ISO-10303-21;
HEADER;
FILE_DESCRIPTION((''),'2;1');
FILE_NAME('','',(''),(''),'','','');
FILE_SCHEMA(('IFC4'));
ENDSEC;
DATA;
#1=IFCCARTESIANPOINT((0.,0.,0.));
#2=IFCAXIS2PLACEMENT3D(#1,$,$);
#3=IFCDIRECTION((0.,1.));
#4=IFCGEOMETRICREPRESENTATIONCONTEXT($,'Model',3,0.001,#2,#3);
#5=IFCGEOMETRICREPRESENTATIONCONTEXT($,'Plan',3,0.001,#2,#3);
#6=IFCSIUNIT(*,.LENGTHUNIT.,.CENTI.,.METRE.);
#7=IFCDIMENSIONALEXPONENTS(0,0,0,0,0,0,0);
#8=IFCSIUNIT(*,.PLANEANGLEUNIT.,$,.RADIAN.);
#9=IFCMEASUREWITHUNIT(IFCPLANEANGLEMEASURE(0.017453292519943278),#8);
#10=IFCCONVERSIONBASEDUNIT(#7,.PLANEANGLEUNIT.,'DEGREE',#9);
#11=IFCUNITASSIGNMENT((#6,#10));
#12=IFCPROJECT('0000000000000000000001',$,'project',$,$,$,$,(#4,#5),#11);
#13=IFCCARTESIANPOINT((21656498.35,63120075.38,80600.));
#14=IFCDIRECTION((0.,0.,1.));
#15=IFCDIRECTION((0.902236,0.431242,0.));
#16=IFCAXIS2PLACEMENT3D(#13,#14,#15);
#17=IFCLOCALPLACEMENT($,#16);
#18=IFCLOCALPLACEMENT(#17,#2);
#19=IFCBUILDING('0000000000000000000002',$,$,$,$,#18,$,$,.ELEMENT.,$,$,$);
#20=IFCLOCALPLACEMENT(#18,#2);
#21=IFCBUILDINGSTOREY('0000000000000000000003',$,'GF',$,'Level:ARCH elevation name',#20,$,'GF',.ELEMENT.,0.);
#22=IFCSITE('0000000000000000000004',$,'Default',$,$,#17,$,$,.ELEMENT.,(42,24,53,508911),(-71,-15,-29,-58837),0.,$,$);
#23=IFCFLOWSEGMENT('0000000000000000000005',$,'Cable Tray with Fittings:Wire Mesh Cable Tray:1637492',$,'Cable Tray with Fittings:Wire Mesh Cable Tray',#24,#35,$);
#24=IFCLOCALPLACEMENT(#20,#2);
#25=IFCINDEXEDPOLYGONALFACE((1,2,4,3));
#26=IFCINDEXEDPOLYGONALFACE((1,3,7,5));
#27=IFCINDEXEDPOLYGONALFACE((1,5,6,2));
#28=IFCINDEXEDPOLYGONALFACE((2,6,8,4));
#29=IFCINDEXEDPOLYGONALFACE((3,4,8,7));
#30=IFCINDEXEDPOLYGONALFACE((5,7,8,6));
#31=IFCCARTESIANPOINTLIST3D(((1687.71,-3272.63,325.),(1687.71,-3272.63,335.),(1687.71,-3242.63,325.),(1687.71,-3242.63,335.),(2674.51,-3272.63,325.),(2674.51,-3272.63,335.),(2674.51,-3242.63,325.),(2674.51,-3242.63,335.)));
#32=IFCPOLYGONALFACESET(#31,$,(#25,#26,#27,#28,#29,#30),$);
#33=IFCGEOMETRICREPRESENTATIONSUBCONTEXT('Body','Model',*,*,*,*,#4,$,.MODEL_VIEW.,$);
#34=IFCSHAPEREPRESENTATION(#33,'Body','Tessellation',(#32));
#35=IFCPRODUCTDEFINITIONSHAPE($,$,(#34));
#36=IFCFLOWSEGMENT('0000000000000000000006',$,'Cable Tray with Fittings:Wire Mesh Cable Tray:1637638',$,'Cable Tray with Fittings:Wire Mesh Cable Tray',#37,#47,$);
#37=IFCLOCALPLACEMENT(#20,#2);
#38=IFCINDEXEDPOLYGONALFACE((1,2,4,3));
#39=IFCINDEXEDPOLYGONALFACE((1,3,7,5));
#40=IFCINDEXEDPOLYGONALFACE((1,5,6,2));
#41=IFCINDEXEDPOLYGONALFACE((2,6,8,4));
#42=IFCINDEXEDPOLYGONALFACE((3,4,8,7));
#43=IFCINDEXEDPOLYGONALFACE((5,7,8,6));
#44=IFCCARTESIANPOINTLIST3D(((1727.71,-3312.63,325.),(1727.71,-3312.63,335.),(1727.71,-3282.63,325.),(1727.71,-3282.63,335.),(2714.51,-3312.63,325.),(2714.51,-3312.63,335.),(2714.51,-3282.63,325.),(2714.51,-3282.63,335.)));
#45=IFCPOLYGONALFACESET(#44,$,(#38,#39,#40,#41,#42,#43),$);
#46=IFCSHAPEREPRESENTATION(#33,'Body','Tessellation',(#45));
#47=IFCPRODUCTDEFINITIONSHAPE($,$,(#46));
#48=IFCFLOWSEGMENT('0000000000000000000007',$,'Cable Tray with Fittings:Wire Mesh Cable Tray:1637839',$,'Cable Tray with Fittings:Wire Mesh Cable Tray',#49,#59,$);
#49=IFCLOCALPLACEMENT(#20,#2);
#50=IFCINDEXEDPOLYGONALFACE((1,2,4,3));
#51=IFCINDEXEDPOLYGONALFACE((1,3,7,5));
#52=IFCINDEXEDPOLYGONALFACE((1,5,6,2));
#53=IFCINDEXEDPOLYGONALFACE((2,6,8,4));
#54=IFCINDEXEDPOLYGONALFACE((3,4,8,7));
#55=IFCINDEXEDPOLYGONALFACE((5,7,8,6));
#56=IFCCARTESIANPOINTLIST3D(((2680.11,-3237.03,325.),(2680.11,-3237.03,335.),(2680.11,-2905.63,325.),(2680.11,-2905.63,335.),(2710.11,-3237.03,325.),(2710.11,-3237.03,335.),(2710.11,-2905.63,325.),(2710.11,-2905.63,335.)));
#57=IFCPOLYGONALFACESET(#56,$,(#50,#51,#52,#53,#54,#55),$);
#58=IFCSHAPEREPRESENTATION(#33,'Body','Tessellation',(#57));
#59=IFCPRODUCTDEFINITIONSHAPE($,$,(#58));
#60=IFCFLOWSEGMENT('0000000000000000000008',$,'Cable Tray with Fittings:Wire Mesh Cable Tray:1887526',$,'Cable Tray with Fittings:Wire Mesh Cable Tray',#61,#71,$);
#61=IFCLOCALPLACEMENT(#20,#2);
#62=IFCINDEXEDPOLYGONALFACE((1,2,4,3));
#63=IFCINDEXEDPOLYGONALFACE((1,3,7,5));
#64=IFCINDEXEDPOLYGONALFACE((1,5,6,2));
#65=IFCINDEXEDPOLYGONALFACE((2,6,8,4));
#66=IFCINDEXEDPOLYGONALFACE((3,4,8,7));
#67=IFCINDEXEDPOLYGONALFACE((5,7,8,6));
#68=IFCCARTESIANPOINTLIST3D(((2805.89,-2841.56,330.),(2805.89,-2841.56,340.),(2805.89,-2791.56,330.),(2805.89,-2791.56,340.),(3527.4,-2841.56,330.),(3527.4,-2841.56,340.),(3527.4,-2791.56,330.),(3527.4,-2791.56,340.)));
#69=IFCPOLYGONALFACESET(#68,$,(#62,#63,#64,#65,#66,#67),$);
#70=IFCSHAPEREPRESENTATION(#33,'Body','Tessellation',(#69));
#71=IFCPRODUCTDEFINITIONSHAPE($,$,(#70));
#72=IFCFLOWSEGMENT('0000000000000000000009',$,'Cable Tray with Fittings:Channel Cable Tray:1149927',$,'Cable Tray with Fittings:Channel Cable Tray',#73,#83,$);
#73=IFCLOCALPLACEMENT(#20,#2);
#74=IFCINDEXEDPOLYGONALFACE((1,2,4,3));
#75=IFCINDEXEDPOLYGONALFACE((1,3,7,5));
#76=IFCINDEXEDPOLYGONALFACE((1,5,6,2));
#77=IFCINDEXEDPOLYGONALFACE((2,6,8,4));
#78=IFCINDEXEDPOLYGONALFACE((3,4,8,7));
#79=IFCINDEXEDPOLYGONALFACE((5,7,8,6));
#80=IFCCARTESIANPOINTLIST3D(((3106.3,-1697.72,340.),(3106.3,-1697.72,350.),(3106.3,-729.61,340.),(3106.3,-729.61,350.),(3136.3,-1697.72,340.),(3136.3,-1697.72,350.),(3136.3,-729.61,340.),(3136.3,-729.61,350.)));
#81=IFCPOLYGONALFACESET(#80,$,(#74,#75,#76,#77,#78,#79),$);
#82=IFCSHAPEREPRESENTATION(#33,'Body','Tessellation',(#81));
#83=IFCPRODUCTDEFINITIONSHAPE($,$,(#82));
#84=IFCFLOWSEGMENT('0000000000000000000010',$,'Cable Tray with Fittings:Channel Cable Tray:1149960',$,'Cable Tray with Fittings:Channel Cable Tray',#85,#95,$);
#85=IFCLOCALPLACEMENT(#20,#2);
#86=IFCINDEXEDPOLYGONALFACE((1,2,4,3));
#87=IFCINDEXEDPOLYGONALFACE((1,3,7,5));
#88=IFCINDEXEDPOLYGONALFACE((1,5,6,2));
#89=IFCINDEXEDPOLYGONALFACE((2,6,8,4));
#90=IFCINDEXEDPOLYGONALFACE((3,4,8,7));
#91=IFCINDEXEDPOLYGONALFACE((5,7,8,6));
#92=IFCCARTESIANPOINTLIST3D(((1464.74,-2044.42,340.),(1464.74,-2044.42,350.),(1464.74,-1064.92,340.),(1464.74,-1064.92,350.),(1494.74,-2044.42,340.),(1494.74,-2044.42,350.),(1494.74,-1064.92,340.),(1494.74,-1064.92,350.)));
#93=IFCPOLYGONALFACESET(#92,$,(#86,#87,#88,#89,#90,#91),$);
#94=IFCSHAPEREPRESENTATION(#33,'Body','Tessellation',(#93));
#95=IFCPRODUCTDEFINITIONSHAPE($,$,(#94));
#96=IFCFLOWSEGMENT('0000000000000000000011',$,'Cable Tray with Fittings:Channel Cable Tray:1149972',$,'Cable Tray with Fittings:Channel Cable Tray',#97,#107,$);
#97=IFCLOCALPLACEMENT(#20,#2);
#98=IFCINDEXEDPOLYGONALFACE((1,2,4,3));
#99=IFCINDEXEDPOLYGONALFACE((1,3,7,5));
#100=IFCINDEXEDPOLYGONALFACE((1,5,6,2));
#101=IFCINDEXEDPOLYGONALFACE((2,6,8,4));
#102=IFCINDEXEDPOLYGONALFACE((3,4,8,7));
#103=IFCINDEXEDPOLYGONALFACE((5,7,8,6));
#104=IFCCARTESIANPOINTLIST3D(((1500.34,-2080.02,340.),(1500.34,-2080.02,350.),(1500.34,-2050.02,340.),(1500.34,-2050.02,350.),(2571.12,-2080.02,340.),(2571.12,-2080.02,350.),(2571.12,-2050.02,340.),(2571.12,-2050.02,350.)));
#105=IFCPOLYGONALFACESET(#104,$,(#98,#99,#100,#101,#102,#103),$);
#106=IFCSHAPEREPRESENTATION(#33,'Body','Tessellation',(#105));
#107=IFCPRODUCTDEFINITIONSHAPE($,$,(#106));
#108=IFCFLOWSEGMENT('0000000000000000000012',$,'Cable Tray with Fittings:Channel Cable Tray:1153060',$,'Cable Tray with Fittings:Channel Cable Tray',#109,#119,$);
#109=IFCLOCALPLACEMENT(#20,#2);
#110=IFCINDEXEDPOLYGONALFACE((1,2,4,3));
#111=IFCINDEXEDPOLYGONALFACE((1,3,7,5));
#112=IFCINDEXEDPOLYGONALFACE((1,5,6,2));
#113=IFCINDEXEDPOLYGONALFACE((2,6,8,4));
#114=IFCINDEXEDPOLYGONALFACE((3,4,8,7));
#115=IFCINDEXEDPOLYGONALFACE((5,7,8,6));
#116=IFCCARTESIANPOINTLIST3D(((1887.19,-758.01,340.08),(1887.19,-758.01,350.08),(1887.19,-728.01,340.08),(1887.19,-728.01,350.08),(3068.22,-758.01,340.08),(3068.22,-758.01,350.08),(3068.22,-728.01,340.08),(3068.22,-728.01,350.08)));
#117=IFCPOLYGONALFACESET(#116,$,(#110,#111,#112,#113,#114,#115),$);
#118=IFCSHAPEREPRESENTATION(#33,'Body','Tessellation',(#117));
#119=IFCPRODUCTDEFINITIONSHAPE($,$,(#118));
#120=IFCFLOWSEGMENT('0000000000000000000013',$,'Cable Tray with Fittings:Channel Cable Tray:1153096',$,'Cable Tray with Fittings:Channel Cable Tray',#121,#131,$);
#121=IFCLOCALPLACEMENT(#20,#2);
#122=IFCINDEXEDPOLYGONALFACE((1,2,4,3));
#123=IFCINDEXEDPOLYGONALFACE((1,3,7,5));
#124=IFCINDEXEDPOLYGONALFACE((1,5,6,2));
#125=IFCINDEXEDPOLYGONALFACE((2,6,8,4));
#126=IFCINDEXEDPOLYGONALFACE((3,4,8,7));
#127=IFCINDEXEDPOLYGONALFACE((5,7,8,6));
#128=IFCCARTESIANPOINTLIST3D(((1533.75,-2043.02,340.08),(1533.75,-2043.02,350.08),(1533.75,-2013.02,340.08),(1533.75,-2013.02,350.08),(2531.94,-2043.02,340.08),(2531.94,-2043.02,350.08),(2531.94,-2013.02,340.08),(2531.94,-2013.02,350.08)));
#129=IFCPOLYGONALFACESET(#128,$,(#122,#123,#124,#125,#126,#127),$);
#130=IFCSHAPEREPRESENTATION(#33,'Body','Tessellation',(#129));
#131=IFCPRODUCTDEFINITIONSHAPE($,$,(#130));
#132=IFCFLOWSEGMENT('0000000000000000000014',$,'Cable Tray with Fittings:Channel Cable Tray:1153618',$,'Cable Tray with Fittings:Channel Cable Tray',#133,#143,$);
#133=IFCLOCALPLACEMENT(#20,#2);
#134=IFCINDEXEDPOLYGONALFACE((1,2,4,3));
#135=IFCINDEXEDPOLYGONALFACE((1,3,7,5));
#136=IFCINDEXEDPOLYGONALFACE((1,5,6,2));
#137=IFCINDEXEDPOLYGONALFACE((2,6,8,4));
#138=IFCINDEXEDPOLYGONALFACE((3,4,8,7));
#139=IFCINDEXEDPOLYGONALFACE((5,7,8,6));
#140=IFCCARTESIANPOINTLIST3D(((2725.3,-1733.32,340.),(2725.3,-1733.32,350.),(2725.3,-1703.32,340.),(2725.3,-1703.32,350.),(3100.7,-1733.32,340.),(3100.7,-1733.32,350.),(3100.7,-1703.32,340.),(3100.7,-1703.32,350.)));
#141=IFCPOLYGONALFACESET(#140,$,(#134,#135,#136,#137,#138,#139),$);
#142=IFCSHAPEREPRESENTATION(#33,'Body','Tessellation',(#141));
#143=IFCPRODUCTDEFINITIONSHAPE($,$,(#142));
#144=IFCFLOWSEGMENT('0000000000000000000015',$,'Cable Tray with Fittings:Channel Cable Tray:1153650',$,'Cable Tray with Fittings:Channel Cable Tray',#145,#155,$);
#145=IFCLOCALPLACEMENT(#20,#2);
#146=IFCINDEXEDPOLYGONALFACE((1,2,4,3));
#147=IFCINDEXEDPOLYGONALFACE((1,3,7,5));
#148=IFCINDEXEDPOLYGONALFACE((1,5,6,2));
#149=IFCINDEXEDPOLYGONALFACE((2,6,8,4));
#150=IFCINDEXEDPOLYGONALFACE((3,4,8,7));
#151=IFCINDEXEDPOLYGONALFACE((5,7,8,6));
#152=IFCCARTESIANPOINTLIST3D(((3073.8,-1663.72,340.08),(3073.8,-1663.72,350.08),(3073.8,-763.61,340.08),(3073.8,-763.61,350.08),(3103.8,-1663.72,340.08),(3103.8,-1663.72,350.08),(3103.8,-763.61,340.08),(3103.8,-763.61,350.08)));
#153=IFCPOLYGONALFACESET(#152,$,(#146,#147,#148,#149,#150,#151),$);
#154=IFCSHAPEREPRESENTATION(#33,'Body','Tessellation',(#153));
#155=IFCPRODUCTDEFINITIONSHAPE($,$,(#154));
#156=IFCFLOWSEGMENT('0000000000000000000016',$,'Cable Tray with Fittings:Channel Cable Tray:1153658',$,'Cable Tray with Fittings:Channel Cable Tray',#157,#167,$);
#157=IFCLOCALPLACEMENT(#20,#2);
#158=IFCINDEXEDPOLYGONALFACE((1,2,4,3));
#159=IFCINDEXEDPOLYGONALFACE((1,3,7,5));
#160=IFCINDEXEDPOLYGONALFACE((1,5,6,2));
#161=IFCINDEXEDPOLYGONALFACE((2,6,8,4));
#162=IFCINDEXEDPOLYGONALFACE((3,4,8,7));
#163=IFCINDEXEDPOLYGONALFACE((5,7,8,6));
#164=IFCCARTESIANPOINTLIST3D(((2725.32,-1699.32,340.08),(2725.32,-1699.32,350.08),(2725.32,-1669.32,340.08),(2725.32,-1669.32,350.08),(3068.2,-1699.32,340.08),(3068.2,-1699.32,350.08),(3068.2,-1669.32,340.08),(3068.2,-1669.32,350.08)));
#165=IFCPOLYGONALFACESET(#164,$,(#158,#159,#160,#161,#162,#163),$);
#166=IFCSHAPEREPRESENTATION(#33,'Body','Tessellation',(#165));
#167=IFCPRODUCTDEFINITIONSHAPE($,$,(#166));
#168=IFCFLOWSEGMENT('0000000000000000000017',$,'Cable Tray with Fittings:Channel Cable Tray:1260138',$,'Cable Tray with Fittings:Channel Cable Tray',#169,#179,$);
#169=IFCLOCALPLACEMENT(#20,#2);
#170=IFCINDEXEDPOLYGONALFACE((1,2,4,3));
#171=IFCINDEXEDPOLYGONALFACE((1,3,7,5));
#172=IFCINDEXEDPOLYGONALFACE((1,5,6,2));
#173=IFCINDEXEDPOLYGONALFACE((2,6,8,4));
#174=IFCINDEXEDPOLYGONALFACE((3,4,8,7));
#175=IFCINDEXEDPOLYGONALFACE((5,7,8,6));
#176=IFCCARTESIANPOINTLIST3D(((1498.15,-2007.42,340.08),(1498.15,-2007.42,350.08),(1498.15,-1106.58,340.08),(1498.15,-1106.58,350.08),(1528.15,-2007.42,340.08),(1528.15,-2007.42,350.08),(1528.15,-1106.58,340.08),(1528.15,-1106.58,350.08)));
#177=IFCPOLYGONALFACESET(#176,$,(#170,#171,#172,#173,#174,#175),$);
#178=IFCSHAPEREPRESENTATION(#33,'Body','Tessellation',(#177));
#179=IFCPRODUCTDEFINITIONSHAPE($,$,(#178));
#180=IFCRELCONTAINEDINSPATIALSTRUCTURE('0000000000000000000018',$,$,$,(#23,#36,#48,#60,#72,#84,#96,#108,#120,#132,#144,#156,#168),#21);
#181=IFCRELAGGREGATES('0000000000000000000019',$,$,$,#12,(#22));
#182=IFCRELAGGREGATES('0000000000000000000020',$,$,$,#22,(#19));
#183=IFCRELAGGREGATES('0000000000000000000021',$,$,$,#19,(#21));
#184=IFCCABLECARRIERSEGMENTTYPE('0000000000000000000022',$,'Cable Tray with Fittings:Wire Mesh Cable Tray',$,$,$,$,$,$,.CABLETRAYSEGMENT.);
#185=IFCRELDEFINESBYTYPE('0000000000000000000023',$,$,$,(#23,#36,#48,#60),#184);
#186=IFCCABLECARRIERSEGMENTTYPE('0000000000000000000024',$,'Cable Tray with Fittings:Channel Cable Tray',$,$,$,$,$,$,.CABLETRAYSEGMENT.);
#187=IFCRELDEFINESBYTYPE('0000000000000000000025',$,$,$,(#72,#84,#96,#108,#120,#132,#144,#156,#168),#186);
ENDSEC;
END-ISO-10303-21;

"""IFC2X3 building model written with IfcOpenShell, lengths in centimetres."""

from ifc_helpers import new_model, entity, si_unit, converted_unit, direction, frame, frame_2d, origin, origin_2d_with_axis, place, context, subcontext, project, spatial, rectangle, extrude, type_object, element, save


model = new_model("IFC2X3")

# Units and contexts
model_context = context("Model", 3, precision=0.001, world=origin(), true_north=direction((0.0, 1.0)))
plan_context = context("Plan", 3, precision=0.001, world=origin(), true_north=direction((0.0, 1.0)))
body_context = subcontext(model_context, "Body", "Model", "MODEL_VIEW")
ifc_project = project(units=[si_unit("LENGTHUNIT", "METRE", prefix="CENTI"), converted_unit("PLANEANGLEUNIT", "DEGREE", entity("IfcPlaneAngleMeasure", 0.017453292519943278), si_unit("PLANEANGLEUNIT", "RADIAN"), dimensions=[0, 0, 0, 0, 0, 0, 0])], contexts=[model_context, plan_context])

# Site, building, storey
site_placement = place(None, frame((21656498.35, 63120075.38, 80600.0), z_axis=(0.0, 0.0, 1.0), x_axis=(0.902236, 0.431242, 0.0)))
site = spatial("IfcSite", under=ifc_project, at=site_placement, Name="Default", CompositionType="ELEMENT", RefLatitude=(42, 24, 53, 508911), RefLongitude=(-71, -15, -29, -58837), RefElevation=0.0)
building_placement = place(site_placement, origin())
building = spatial("IfcBuilding", under=site, at=building_placement, CompositionType="ELEMENT")
storey_placement = place(building_placement, origin())
storey = spatial("IfcBuildingStorey", under=building, at=storey_placement, Name="GF", ObjectType="Level:ARCH elevation name", LongName="GF", CompositionType="ELEMENT", Elevation=0.0)

# Flow segments
cable_carrier_segment_type_1 = type_object("IfcCableCarrierSegmentType", Name="Cable Tray with Fittings:Wire Mesh Cable Tray", PredefinedType="CABLETRAYSEGMENT")
flow_segment_1_placement = place(storey_placement, origin())
element("IfcFlowSegment", 1, at=flow_segment_1_placement, inside=storey, type_object=cable_carrier_segment_type_1, Name="Cable Tray with Fittings:Wire Mesh Cable Tray:1637492", ObjectType="Cable Tray with Fittings:Wire Mesh Cable Tray", context=body_context, shape_type="SweptSolid", body=[
    extrude(rectangle(XDim=986.8, YDim=30.0, at=frame_2d((0.0, 0.0), x_axis=(1.0, 0.0))), frame((2181.11, -3257.63, 325.0), z_axis=(0.0, 0.0, 1.0), x_axis=(-1.0, 0.0, 0.0)), (0.0, 0.0, 1.0), 10.0),
])
flow_segment_2_placement = place(storey_placement, origin())
element("IfcFlowSegment", 2, at=flow_segment_2_placement, inside=storey, type_object=cable_carrier_segment_type_1, Name="Cable Tray with Fittings:Wire Mesh Cable Tray:1637638", ObjectType="Cable Tray with Fittings:Wire Mesh Cable Tray", context=body_context, shape_type="SweptSolid", body=[
    extrude(rectangle(XDim=986.8, YDim=30.0, at=frame_2d((0.0, 0.0), x_axis=(1.0, 0.0))), frame((2221.11, -3297.63, 325.0), z_axis=(0.0, 0.0, 1.0), x_axis=(-1.0, 0.0, 0.0)), (0.0, 0.0, 1.0), 10.0),
])
flow_segment_3_placement = place(storey_placement, origin())
element("IfcFlowSegment", 3, at=flow_segment_3_placement, inside=storey, type_object=cable_carrier_segment_type_1, Name="Cable Tray with Fittings:Wire Mesh Cable Tray:1637839", ObjectType="Cable Tray with Fittings:Wire Mesh Cable Tray", context=body_context, shape_type="SweptSolid", body=[
    extrude(rectangle(XDim=331.4, YDim=30.0, at=origin_2d_with_axis()), frame((2695.11, -3071.33, 325.0), z_axis=(0.0, 0.0, 1.0), x_axis=(0.0, 1.0, 0.0)), (0.0, 0.0, 1.0), 10.0),
])
flow_segment_4_placement = place(storey_placement, origin())
element("IfcFlowSegment", 4, at=flow_segment_4_placement, inside=storey, type_object=cable_carrier_segment_type_1, Name="Cable Tray with Fittings:Wire Mesh Cable Tray:1887526", ObjectType="Cable Tray with Fittings:Wire Mesh Cable Tray", context=body_context, shape_type="SweptSolid", body=[
    extrude(rectangle(XDim=721.51, YDim=50.0, at=origin_2d_with_axis()), frame((3166.65, -2816.56, 330.0), z_axis=(0.0, 0.0, 1.0), x_axis=(-1.0, 0.0, 0.0)), (0.0, 0.0, 1.0), 10.0),
])
cable_carrier_segment_type_2 = type_object("IfcCableCarrierSegmentType", Name="Cable Tray with Fittings:Channel Cable Tray", PredefinedType="CABLETRAYSEGMENT")
flow_segment_5_placement = place(storey_placement, origin())
element("IfcFlowSegment", 5, at=flow_segment_5_placement, inside=storey, type_object=cable_carrier_segment_type_2, Name="Cable Tray with Fittings:Channel Cable Tray:1149927", ObjectType="Cable Tray with Fittings:Channel Cable Tray", context=body_context, shape_type="SweptSolid", body=[
    extrude(rectangle(XDim=968.1, YDim=30.0, at=frame_2d((0.0, 0.0), x_axis=(1.0, 0.0))), frame((3121.3, -1213.67, 340.0), z_axis=(0.0, 0.0, 1.0), x_axis=(0.0, -1.0, 0.0)), (0.0, 0.0, 1.0), 10.0),
])
flow_segment_6_placement = place(storey_placement, origin())
element("IfcFlowSegment", 6, at=flow_segment_6_placement, inside=storey, type_object=cable_carrier_segment_type_2, Name="Cable Tray with Fittings:Channel Cable Tray:1149960", ObjectType="Cable Tray with Fittings:Channel Cable Tray", context=body_context, shape_type="SweptSolid", body=[
    extrude(rectangle(XDim=979.5, YDim=30.0, at=frame_2d((0.0, 0.0), x_axis=(1.0, 0.0))), frame((1479.74, -1554.67, 340.0), z_axis=(0.0, 0.0, 1.0), x_axis=(0.0, -1.0, 0.0)), (0.0, 0.0, 1.0), 10.0),
])
flow_segment_7_placement = place(storey_placement, origin())
element("IfcFlowSegment", 7, at=flow_segment_7_placement, inside=storey, type_object=cable_carrier_segment_type_2, Name="Cable Tray with Fittings:Channel Cable Tray:1149972", ObjectType="Cable Tray with Fittings:Channel Cable Tray", context=body_context, shape_type="SweptSolid", body=[
    extrude(rectangle(XDim=1070.78, YDim=30.0, at=frame_2d((0.0, 0.0), x_axis=(1.0, 0.0))), frame((2035.73, -2065.02, 340.0), z_axis=(0.0, 0.0, 1.0), x_axis=(-1.0, 0.0, 0.0)), (0.0, 0.0, 1.0), 10.0),
])
flow_segment_8_placement = place(storey_placement, origin())
element("IfcFlowSegment", 8, at=flow_segment_8_placement, inside=storey, type_object=cable_carrier_segment_type_2, Name="Cable Tray with Fittings:Channel Cable Tray:1153060", ObjectType="Cable Tray with Fittings:Channel Cable Tray", context=body_context, shape_type="SweptSolid", body=[
    extrude(rectangle(XDim=1181.03, YDim=30.0, at=origin_2d_with_axis()), frame((2477.71, -743.01, 340.08), z_axis=(0.0, 0.0, 1.0), x_axis=(-1.0, 0.0, 0.0)), (0.0, 0.0, 1.0), 10.0),
])
flow_segment_9_placement = place(storey_placement, origin())
element("IfcFlowSegment", 9, at=flow_segment_9_placement, inside=storey, type_object=cable_carrier_segment_type_2, Name="Cable Tray with Fittings:Channel Cable Tray:1153096", ObjectType="Cable Tray with Fittings:Channel Cable Tray", context=body_context, shape_type="SweptSolid", body=[
    extrude(rectangle(XDim=998.19, YDim=30.0, at=frame_2d((0.0, 0.0), x_axis=(1.0, 0.0))), frame((2032.85, -2028.02, 340.08), z_axis=(0.0, 0.0, 1.0), x_axis=(-1.0, 0.0, 0.0)), (0.0, 0.0, 1.0), 10.0),
])
flow_segment_10_placement = place(storey_placement, origin())
element("IfcFlowSegment", 10, at=flow_segment_10_placement, inside=storey, type_object=cable_carrier_segment_type_2, Name="Cable Tray with Fittings:Channel Cable Tray:1153618", ObjectType="Cable Tray with Fittings:Channel Cable Tray", context=body_context, shape_type="SweptSolid", body=[
    extrude(rectangle(XDim=375.4, YDim=30.0, at=frame_2d((0.0, 0.0), x_axis=(1.0, 0.0))), frame((2913.0, -1718.32, 340.0), z_axis=(0.0, 0.0, 1.0), x_axis=(-1.0, 0.0, 0.0)), (0.0, 0.0, 1.0), 10.0),
])
flow_segment_11_placement = place(storey_placement, origin())
element("IfcFlowSegment", 11, at=flow_segment_11_placement, inside=storey, type_object=cable_carrier_segment_type_2, Name="Cable Tray with Fittings:Channel Cable Tray:1153650", ObjectType="Cable Tray with Fittings:Channel Cable Tray", context=body_context, shape_type="SweptSolid", body=[
    extrude(rectangle(XDim=900.1, YDim=30.0, at=origin_2d_with_axis()), frame((3088.8, -1213.67, 340.08), z_axis=(0.0, 0.0, 1.0), x_axis=(0.0, -1.0, 0.0)), (0.0, 0.0, 1.0), 10.0),
])
flow_segment_12_placement = place(storey_placement, origin())
element("IfcFlowSegment", 12, at=flow_segment_12_placement, inside=storey, type_object=cable_carrier_segment_type_2, Name="Cable Tray with Fittings:Channel Cable Tray:1153658", ObjectType="Cable Tray with Fittings:Channel Cable Tray", context=body_context, shape_type="SweptSolid", body=[
    extrude(rectangle(XDim=342.88, YDim=30.0, at=frame_2d((0.0, 0.0), x_axis=(1.0, 0.0))), frame((2896.76, -1684.32, 340.08), z_axis=(0.0, 0.0, 1.0), x_axis=(-1.0, 0.0, 0.0)), (0.0, 0.0, 1.0), 10.0),
])
flow_segment_13_placement = place(storey_placement, origin())
element("IfcFlowSegment", 13, at=flow_segment_13_placement, inside=storey, type_object=cable_carrier_segment_type_2, Name="Cable Tray with Fittings:Channel Cable Tray:1260138", ObjectType="Cable Tray with Fittings:Channel Cable Tray", context=body_context, shape_type="SweptSolid", body=[
    extrude(rectangle(XDim=900.84, YDim=30.0, at=frame_2d((0.0, 0.0), x_axis=(1.0, 0.0))), frame((1513.15, -1557.0, 340.08), z_axis=(0.0, 0.0, 1.0), x_axis=(0.0, 1.0, 0.0)), (0.0, 0.0, 1.0), 10.0),
])

save(model, "model.ifc")
